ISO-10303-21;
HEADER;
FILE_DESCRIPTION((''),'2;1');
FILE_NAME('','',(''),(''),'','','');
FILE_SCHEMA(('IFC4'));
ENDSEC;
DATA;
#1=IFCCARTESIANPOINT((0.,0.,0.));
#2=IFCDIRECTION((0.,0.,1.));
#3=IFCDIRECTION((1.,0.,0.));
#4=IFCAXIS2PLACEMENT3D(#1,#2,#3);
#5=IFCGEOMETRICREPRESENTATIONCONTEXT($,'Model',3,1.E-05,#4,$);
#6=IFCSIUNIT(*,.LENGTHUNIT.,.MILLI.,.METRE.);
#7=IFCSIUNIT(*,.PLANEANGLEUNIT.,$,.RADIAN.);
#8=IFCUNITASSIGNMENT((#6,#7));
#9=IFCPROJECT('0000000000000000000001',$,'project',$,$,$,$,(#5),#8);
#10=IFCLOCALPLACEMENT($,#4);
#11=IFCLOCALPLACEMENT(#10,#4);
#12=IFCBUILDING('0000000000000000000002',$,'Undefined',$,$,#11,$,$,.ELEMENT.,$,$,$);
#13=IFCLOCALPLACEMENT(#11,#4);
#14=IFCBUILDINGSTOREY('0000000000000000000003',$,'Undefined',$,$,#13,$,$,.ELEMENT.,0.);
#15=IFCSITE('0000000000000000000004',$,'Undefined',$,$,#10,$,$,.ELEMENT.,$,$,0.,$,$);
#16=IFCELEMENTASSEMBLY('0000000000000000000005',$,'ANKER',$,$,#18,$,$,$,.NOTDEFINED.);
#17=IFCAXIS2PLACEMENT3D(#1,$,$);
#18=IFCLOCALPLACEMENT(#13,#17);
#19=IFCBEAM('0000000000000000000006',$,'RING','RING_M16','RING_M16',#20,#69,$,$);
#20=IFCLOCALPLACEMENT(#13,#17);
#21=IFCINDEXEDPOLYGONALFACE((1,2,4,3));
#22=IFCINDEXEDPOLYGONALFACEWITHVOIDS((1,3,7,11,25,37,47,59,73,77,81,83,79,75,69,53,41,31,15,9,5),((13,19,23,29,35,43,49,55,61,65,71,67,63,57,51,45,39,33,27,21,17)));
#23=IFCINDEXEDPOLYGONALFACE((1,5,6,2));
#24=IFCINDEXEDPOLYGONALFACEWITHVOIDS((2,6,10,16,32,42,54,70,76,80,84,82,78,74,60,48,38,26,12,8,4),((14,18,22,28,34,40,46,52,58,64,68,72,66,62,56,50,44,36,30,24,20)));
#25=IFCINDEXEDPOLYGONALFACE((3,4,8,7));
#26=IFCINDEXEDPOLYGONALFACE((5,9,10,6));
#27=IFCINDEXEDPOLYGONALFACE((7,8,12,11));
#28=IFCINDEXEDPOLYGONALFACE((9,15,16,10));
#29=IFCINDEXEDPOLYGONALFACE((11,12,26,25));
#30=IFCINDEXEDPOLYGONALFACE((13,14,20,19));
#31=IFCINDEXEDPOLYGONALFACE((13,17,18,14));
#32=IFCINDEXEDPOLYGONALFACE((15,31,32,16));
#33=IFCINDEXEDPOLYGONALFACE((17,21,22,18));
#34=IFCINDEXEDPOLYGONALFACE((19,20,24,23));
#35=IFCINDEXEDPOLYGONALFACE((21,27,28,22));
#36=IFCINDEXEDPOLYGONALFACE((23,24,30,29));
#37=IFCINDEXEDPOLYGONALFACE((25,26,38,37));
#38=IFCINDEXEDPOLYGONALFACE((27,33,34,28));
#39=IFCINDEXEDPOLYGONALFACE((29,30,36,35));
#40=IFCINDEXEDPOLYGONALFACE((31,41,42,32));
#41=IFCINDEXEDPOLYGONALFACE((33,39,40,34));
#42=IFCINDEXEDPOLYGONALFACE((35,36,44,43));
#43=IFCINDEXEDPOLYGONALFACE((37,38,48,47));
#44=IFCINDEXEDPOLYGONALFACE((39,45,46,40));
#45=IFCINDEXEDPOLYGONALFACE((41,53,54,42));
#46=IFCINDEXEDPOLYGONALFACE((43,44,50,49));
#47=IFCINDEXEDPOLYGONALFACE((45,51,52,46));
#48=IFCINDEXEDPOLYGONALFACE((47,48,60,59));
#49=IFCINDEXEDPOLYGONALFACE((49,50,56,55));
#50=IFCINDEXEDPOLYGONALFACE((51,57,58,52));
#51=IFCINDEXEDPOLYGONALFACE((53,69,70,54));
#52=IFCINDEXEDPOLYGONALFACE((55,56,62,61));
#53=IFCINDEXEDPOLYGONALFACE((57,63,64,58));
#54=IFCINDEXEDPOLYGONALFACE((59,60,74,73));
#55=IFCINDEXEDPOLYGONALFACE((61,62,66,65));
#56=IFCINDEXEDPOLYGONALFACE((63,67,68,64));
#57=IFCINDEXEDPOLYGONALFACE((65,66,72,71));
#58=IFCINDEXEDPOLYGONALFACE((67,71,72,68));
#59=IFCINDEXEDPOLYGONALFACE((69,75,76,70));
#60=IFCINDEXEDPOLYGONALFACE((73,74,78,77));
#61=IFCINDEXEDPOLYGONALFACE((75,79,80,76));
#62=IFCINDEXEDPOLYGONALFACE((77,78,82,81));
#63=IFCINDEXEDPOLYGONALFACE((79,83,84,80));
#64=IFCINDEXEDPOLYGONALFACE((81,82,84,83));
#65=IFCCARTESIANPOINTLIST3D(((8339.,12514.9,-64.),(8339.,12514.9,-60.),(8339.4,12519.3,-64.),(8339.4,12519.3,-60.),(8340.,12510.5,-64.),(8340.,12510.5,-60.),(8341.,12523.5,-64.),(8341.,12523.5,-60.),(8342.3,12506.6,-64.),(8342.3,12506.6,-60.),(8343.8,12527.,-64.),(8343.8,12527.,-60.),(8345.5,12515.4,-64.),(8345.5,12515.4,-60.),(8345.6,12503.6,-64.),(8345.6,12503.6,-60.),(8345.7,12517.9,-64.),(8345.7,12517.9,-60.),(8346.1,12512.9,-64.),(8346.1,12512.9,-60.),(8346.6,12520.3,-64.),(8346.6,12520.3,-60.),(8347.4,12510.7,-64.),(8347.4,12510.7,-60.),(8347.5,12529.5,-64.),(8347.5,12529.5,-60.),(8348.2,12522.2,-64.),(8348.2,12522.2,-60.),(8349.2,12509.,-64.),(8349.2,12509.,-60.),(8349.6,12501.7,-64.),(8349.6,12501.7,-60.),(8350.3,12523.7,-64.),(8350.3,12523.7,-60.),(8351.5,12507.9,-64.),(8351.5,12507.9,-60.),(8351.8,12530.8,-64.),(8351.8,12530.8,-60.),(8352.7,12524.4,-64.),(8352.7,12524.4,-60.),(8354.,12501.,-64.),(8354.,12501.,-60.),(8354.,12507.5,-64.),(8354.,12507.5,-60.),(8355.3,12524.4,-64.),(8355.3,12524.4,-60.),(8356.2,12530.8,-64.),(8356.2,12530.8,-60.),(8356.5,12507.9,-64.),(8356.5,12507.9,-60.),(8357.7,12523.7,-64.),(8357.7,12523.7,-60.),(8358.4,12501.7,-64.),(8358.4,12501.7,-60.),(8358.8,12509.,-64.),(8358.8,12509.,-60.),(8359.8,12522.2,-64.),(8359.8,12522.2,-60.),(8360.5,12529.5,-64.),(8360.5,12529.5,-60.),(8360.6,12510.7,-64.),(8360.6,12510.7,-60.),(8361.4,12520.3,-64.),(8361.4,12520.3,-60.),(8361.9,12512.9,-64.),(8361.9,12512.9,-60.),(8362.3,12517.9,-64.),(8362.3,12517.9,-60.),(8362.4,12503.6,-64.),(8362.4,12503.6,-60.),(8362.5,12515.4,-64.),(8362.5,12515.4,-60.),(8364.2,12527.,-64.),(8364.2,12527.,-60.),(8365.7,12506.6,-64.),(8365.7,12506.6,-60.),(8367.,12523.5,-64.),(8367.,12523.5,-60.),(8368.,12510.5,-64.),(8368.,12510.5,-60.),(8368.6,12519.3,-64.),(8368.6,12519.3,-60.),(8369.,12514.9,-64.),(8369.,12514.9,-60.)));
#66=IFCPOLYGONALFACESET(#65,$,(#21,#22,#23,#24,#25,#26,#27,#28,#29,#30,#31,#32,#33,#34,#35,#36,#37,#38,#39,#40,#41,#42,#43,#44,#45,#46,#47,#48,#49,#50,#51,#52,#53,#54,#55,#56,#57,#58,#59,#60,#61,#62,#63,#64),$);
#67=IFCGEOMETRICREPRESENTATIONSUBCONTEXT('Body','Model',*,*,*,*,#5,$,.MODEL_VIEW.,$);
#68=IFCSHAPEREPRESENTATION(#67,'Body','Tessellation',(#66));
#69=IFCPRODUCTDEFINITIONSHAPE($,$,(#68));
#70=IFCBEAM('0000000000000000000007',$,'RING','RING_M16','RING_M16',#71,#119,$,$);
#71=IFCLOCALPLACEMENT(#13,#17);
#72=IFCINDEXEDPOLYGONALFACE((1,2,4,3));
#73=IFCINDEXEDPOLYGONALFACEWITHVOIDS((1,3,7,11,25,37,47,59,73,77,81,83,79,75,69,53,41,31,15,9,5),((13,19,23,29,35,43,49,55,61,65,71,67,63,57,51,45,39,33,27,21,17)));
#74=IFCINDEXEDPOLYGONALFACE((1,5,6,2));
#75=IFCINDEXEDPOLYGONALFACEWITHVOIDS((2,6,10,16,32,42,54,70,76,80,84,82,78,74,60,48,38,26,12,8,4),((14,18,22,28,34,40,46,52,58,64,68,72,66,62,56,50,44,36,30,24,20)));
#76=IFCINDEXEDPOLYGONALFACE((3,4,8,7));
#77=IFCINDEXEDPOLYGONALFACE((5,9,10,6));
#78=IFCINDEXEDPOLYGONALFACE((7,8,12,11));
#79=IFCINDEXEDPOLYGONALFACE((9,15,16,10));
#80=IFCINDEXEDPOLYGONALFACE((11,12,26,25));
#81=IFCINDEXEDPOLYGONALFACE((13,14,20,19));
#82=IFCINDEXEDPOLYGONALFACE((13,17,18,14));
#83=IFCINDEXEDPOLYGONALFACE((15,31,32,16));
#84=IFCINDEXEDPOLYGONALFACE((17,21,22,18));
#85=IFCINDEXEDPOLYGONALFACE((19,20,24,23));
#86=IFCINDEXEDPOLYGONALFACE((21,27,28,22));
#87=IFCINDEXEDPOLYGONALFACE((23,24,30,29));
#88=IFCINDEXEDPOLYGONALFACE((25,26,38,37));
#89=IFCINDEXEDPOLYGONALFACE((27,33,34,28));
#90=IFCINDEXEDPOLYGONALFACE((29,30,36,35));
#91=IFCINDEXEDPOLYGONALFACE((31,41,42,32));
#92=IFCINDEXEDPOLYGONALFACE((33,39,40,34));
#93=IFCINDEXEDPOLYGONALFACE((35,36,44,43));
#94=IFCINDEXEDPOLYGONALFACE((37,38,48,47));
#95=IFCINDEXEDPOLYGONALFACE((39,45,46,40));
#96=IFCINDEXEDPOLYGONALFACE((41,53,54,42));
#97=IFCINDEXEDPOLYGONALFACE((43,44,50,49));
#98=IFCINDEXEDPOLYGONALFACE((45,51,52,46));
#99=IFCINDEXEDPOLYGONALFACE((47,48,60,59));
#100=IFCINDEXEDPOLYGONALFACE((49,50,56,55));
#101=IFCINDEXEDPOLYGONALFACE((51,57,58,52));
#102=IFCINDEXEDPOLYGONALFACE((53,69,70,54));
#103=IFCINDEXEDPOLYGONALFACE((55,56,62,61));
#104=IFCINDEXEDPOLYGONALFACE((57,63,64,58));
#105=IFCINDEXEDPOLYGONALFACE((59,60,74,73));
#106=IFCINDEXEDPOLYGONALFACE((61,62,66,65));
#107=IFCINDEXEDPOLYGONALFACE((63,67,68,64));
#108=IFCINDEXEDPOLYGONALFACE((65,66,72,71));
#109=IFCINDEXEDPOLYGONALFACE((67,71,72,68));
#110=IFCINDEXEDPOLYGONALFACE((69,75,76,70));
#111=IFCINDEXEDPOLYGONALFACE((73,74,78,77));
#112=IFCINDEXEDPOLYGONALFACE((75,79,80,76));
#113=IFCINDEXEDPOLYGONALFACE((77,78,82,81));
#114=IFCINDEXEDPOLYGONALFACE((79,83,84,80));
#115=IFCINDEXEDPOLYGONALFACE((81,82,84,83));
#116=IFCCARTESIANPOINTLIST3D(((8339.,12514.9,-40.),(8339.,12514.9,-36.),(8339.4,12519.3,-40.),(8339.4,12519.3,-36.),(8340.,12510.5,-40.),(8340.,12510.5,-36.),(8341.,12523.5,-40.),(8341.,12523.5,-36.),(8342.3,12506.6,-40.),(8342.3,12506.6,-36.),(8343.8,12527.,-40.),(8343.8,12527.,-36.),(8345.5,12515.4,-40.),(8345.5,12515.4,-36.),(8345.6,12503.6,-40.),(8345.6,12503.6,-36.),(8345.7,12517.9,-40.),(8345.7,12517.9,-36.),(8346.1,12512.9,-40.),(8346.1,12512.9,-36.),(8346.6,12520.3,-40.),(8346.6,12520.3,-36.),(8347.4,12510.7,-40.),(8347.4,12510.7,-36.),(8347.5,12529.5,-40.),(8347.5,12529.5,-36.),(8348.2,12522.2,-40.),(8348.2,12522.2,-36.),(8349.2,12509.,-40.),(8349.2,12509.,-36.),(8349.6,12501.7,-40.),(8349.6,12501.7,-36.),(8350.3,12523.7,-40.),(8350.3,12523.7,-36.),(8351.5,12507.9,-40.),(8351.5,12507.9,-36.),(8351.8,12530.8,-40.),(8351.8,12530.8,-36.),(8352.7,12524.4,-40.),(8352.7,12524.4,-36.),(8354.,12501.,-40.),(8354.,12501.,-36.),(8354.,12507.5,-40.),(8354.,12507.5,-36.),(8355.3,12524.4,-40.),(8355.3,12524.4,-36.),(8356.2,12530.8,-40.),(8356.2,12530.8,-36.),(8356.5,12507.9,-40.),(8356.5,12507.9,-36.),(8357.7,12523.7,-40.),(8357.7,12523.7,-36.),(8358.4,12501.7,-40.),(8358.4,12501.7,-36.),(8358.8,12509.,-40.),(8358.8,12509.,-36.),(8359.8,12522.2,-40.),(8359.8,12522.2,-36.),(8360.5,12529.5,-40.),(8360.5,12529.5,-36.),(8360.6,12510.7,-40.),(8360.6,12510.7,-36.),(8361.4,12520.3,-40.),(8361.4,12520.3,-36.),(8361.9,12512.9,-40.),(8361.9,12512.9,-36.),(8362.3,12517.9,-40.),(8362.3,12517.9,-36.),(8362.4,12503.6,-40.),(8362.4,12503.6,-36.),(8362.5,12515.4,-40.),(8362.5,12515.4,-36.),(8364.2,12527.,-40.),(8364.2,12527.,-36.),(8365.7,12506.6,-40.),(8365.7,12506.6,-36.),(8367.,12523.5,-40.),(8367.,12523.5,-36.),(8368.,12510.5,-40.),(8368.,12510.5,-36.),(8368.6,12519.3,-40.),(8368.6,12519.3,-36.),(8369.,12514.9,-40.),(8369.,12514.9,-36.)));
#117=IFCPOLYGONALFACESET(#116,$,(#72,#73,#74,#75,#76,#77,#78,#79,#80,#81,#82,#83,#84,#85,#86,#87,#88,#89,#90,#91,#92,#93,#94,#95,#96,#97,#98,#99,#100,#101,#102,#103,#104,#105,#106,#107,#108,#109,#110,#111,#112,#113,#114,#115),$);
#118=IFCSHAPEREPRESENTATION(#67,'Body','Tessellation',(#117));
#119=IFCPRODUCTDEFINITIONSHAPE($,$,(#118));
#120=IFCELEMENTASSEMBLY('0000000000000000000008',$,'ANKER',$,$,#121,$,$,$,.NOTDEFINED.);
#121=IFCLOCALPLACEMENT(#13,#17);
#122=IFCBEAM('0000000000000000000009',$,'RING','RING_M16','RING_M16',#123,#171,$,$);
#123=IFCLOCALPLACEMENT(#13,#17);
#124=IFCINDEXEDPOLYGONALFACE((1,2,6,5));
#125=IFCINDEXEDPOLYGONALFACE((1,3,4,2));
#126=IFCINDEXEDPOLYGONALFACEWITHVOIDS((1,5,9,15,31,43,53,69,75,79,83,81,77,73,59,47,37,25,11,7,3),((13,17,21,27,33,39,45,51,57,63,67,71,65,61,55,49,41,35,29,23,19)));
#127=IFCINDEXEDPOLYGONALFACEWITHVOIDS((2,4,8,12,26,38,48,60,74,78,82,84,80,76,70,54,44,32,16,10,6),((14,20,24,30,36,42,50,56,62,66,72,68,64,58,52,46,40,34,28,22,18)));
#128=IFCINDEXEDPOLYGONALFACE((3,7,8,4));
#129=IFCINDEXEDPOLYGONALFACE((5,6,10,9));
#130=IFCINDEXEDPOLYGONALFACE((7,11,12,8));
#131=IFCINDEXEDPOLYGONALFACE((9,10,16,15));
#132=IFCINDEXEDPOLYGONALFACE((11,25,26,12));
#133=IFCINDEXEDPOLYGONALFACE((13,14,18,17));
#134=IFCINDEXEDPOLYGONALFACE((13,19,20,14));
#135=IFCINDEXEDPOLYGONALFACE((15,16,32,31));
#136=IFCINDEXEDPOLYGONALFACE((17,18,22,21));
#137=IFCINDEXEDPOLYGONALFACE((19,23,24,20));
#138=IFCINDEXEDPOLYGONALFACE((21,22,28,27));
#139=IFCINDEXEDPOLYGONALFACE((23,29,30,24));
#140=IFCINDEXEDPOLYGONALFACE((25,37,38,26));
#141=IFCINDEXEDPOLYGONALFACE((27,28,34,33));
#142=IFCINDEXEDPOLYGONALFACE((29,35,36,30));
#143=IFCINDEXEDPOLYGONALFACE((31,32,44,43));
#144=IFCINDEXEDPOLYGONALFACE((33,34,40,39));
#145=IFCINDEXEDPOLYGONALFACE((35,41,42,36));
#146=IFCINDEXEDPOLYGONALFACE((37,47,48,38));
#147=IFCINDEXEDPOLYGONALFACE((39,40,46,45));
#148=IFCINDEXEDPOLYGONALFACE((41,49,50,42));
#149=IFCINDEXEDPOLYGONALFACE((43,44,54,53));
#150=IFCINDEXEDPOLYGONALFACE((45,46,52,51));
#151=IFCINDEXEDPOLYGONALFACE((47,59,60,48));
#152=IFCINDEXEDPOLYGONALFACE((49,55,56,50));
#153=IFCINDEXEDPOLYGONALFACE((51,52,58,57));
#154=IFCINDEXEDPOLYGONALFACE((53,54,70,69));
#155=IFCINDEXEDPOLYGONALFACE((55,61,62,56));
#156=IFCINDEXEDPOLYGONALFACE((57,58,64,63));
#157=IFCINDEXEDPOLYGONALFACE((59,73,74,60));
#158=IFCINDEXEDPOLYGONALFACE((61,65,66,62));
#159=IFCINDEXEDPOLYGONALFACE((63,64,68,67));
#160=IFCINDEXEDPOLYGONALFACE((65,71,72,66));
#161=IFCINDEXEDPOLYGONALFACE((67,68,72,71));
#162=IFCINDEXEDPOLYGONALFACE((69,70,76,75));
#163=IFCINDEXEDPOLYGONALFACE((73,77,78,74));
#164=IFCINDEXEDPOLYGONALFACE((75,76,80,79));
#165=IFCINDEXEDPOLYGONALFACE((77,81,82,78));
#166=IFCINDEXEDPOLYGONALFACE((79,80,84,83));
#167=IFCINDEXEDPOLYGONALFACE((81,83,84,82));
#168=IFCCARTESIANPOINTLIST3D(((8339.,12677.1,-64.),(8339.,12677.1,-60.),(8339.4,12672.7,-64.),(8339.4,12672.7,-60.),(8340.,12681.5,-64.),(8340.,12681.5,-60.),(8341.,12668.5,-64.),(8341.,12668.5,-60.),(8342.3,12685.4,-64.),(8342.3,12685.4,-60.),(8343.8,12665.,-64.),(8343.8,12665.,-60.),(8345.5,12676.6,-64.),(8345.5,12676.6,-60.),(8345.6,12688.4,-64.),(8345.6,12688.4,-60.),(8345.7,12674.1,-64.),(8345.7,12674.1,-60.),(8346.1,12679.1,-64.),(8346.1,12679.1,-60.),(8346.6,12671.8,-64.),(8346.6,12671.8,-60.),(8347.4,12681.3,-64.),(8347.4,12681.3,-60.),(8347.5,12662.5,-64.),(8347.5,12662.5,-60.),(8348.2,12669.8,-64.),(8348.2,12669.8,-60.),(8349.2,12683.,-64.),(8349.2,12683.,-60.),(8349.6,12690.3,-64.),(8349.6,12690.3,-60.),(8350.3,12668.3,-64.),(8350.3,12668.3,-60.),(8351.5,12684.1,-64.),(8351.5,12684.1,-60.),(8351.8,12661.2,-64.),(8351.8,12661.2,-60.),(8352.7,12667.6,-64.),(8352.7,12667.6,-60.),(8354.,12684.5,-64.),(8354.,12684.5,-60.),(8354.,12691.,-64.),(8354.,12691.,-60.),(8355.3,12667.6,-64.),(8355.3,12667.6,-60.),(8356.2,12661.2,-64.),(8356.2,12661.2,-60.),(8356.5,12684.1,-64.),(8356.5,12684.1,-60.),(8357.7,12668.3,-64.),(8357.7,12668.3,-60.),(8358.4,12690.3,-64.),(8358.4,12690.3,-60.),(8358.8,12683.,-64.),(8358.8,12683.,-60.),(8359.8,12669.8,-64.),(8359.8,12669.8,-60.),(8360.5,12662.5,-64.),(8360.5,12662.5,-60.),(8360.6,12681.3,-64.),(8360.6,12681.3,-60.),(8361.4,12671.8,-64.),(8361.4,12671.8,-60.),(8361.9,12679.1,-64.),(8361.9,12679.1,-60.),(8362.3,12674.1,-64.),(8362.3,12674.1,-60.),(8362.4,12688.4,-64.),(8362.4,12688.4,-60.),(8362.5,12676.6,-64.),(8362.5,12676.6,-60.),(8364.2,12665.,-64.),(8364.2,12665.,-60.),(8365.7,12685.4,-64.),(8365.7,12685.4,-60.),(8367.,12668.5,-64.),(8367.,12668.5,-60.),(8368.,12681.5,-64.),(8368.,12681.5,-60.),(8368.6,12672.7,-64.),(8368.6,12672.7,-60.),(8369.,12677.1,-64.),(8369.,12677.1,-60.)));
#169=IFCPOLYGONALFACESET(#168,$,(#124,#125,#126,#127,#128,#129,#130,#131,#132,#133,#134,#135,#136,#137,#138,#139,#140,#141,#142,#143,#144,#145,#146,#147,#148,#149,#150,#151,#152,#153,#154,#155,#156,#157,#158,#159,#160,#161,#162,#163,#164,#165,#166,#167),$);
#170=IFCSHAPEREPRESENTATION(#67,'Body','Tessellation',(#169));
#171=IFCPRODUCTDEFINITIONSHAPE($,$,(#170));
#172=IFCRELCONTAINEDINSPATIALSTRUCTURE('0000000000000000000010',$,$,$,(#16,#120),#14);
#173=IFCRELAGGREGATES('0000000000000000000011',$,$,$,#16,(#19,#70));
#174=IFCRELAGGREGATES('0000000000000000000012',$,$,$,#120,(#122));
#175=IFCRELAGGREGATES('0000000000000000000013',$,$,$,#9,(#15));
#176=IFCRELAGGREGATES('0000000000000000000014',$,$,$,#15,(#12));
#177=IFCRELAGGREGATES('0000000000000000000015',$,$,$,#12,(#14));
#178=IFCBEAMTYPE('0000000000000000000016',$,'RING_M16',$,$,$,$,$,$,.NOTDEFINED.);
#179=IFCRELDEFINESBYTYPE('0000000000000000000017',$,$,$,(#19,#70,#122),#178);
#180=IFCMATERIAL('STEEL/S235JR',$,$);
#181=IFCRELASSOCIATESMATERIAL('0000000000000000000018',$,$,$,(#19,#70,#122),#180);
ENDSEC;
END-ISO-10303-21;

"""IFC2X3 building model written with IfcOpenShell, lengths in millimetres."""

from ifc_helpers import new_model, si_unit, frame, origin_with_axes, origin_2d_with_axis, place, context, subcontext, project, spatial, hollow_circle, extrude, material, type_object, element, aggregate, save


model = new_model("IFC2X3")

# Units and contexts
model_context = context("Model", 3, precision=1e-05, world=origin_with_axes())
body_context = subcontext(model_context, "Body", "Model", "MODEL_VIEW")
ifc_project = project(units=[si_unit("LENGTHUNIT", "METRE", prefix="MILLI"), si_unit("PLANEANGLEUNIT", "RADIAN")], contexts=[model_context])

# Site, building, storey
site_placement = place(None, origin_with_axes())
site = spatial("IfcSite", under=ifc_project, at=site_placement, Name="Undefined", CompositionType="ELEMENT", RefElevation=0.0)
building_placement = place(site_placement, origin_with_axes())
building = spatial("IfcBuilding", under=site, at=building_placement, Name="Undefined", CompositionType="ELEMENT")
storey_placement = place(building_placement, origin_with_axes())
storey = spatial("IfcBuildingStorey", under=building, at=storey_placement, Name="Undefined", CompositionType="ELEMENT", Elevation=0.0)

# Shared definitions
ifc_material = material(Name="STEEL/S235JR")

# Element assemblies, beams
assembly_1_placement = place(storey_placement, frame((8354.0, 12516.0, 10.0), z_axis=(1.0, 0.0, 0.0), x_axis=(0.0, 0.0, -1.0)))
assembly_1 = element("IfcElementAssembly", 1, at=assembly_1_placement, inside=storey, Name="ANKER", PredefinedType="NOTDEFINED")
beam_type_1 = type_object("IfcBeamType", Name="RING_M16", PredefinedType="NOTDEFINED")
beam_1_placement = place(storey_placement, frame((8354.0, 12516.0, -60.0), z_axis=(1.0, 0.0, 0.0), x_axis=(0.0, 0.0, -1.0)))
beam_1 = element("IfcBeam", 2, at=beam_1_placement, type_object=beam_type_1, material=ifc_material, Name="RING", Description="RING_M16", ObjectType="RING_M16", context=body_context, shape_type="SweptSolid", body=[
    extrude(hollow_circle(Radius=15.0, WallThickness=6.5, at=origin_2d_with_axis()), frame((4.0, 0.0, 0.0), z_axis=(-1.0, 0.0, 0.0), x_axis=(0.0, -1.0, 0.0)), (0.0, 0.0, 1.0), 4.0),
])
beam_2_placement = place(storey_placement, frame((8354.0, 12516.0, -36.0), z_axis=(1.0, 0.0, 0.0), x_axis=(0.0, 0.0, -1.0)))
beam_2 = element("IfcBeam", 3, at=beam_2_placement, type_object=beam_type_1, material=ifc_material, Name="RING", Description="RING_M16", ObjectType="RING_M16", context=body_context, shape_type="SweptSolid", body=[
    extrude(hollow_circle(Radius=15.0, WallThickness=6.5, at=origin_2d_with_axis()), frame((4.0, 0.0, 0.0), z_axis=(-1.0, 0.0, 0.0), x_axis=(0.0, -1.0, 0.0)), (0.0, 0.0, 1.0), 4.0),
])
aggregate(assembly_1, [beam_1, beam_2])
assembly_2_placement = place(storey_placement, frame((8354.0, 12676.0, 10.0), z_axis=(-1.0, 0.0, 0.0), x_axis=(0.0, 0.0, -1.0)))
assembly_2 = element("IfcElementAssembly", 4, at=assembly_2_placement, inside=storey, Name="ANKER", PredefinedType="NOTDEFINED")
beam_3_placement = place(storey_placement, frame((8354.0, 12676.0, -60.0), z_axis=(-1.0, 0.0, 0.0), x_axis=(0.0, 0.0, -1.0)))
beam_3 = element("IfcBeam", 5, at=beam_3_placement, type_object=beam_type_1, material=ifc_material, Name="RING", Description="RING_M16", ObjectType="RING_M16", context=body_context, shape_type="SweptSolid", body=[
    extrude(hollow_circle(Radius=15.0, WallThickness=6.5, at=origin_2d_with_axis()), frame((4.0, 0.0, 0.0), z_axis=(-1.0, 0.0, 0.0), x_axis=(0.0, -1.0, 0.0)), (0.0, 0.0, 1.0), 4.0),
])
aggregate(assembly_2, [beam_3])

save(model, "model.ifc")
